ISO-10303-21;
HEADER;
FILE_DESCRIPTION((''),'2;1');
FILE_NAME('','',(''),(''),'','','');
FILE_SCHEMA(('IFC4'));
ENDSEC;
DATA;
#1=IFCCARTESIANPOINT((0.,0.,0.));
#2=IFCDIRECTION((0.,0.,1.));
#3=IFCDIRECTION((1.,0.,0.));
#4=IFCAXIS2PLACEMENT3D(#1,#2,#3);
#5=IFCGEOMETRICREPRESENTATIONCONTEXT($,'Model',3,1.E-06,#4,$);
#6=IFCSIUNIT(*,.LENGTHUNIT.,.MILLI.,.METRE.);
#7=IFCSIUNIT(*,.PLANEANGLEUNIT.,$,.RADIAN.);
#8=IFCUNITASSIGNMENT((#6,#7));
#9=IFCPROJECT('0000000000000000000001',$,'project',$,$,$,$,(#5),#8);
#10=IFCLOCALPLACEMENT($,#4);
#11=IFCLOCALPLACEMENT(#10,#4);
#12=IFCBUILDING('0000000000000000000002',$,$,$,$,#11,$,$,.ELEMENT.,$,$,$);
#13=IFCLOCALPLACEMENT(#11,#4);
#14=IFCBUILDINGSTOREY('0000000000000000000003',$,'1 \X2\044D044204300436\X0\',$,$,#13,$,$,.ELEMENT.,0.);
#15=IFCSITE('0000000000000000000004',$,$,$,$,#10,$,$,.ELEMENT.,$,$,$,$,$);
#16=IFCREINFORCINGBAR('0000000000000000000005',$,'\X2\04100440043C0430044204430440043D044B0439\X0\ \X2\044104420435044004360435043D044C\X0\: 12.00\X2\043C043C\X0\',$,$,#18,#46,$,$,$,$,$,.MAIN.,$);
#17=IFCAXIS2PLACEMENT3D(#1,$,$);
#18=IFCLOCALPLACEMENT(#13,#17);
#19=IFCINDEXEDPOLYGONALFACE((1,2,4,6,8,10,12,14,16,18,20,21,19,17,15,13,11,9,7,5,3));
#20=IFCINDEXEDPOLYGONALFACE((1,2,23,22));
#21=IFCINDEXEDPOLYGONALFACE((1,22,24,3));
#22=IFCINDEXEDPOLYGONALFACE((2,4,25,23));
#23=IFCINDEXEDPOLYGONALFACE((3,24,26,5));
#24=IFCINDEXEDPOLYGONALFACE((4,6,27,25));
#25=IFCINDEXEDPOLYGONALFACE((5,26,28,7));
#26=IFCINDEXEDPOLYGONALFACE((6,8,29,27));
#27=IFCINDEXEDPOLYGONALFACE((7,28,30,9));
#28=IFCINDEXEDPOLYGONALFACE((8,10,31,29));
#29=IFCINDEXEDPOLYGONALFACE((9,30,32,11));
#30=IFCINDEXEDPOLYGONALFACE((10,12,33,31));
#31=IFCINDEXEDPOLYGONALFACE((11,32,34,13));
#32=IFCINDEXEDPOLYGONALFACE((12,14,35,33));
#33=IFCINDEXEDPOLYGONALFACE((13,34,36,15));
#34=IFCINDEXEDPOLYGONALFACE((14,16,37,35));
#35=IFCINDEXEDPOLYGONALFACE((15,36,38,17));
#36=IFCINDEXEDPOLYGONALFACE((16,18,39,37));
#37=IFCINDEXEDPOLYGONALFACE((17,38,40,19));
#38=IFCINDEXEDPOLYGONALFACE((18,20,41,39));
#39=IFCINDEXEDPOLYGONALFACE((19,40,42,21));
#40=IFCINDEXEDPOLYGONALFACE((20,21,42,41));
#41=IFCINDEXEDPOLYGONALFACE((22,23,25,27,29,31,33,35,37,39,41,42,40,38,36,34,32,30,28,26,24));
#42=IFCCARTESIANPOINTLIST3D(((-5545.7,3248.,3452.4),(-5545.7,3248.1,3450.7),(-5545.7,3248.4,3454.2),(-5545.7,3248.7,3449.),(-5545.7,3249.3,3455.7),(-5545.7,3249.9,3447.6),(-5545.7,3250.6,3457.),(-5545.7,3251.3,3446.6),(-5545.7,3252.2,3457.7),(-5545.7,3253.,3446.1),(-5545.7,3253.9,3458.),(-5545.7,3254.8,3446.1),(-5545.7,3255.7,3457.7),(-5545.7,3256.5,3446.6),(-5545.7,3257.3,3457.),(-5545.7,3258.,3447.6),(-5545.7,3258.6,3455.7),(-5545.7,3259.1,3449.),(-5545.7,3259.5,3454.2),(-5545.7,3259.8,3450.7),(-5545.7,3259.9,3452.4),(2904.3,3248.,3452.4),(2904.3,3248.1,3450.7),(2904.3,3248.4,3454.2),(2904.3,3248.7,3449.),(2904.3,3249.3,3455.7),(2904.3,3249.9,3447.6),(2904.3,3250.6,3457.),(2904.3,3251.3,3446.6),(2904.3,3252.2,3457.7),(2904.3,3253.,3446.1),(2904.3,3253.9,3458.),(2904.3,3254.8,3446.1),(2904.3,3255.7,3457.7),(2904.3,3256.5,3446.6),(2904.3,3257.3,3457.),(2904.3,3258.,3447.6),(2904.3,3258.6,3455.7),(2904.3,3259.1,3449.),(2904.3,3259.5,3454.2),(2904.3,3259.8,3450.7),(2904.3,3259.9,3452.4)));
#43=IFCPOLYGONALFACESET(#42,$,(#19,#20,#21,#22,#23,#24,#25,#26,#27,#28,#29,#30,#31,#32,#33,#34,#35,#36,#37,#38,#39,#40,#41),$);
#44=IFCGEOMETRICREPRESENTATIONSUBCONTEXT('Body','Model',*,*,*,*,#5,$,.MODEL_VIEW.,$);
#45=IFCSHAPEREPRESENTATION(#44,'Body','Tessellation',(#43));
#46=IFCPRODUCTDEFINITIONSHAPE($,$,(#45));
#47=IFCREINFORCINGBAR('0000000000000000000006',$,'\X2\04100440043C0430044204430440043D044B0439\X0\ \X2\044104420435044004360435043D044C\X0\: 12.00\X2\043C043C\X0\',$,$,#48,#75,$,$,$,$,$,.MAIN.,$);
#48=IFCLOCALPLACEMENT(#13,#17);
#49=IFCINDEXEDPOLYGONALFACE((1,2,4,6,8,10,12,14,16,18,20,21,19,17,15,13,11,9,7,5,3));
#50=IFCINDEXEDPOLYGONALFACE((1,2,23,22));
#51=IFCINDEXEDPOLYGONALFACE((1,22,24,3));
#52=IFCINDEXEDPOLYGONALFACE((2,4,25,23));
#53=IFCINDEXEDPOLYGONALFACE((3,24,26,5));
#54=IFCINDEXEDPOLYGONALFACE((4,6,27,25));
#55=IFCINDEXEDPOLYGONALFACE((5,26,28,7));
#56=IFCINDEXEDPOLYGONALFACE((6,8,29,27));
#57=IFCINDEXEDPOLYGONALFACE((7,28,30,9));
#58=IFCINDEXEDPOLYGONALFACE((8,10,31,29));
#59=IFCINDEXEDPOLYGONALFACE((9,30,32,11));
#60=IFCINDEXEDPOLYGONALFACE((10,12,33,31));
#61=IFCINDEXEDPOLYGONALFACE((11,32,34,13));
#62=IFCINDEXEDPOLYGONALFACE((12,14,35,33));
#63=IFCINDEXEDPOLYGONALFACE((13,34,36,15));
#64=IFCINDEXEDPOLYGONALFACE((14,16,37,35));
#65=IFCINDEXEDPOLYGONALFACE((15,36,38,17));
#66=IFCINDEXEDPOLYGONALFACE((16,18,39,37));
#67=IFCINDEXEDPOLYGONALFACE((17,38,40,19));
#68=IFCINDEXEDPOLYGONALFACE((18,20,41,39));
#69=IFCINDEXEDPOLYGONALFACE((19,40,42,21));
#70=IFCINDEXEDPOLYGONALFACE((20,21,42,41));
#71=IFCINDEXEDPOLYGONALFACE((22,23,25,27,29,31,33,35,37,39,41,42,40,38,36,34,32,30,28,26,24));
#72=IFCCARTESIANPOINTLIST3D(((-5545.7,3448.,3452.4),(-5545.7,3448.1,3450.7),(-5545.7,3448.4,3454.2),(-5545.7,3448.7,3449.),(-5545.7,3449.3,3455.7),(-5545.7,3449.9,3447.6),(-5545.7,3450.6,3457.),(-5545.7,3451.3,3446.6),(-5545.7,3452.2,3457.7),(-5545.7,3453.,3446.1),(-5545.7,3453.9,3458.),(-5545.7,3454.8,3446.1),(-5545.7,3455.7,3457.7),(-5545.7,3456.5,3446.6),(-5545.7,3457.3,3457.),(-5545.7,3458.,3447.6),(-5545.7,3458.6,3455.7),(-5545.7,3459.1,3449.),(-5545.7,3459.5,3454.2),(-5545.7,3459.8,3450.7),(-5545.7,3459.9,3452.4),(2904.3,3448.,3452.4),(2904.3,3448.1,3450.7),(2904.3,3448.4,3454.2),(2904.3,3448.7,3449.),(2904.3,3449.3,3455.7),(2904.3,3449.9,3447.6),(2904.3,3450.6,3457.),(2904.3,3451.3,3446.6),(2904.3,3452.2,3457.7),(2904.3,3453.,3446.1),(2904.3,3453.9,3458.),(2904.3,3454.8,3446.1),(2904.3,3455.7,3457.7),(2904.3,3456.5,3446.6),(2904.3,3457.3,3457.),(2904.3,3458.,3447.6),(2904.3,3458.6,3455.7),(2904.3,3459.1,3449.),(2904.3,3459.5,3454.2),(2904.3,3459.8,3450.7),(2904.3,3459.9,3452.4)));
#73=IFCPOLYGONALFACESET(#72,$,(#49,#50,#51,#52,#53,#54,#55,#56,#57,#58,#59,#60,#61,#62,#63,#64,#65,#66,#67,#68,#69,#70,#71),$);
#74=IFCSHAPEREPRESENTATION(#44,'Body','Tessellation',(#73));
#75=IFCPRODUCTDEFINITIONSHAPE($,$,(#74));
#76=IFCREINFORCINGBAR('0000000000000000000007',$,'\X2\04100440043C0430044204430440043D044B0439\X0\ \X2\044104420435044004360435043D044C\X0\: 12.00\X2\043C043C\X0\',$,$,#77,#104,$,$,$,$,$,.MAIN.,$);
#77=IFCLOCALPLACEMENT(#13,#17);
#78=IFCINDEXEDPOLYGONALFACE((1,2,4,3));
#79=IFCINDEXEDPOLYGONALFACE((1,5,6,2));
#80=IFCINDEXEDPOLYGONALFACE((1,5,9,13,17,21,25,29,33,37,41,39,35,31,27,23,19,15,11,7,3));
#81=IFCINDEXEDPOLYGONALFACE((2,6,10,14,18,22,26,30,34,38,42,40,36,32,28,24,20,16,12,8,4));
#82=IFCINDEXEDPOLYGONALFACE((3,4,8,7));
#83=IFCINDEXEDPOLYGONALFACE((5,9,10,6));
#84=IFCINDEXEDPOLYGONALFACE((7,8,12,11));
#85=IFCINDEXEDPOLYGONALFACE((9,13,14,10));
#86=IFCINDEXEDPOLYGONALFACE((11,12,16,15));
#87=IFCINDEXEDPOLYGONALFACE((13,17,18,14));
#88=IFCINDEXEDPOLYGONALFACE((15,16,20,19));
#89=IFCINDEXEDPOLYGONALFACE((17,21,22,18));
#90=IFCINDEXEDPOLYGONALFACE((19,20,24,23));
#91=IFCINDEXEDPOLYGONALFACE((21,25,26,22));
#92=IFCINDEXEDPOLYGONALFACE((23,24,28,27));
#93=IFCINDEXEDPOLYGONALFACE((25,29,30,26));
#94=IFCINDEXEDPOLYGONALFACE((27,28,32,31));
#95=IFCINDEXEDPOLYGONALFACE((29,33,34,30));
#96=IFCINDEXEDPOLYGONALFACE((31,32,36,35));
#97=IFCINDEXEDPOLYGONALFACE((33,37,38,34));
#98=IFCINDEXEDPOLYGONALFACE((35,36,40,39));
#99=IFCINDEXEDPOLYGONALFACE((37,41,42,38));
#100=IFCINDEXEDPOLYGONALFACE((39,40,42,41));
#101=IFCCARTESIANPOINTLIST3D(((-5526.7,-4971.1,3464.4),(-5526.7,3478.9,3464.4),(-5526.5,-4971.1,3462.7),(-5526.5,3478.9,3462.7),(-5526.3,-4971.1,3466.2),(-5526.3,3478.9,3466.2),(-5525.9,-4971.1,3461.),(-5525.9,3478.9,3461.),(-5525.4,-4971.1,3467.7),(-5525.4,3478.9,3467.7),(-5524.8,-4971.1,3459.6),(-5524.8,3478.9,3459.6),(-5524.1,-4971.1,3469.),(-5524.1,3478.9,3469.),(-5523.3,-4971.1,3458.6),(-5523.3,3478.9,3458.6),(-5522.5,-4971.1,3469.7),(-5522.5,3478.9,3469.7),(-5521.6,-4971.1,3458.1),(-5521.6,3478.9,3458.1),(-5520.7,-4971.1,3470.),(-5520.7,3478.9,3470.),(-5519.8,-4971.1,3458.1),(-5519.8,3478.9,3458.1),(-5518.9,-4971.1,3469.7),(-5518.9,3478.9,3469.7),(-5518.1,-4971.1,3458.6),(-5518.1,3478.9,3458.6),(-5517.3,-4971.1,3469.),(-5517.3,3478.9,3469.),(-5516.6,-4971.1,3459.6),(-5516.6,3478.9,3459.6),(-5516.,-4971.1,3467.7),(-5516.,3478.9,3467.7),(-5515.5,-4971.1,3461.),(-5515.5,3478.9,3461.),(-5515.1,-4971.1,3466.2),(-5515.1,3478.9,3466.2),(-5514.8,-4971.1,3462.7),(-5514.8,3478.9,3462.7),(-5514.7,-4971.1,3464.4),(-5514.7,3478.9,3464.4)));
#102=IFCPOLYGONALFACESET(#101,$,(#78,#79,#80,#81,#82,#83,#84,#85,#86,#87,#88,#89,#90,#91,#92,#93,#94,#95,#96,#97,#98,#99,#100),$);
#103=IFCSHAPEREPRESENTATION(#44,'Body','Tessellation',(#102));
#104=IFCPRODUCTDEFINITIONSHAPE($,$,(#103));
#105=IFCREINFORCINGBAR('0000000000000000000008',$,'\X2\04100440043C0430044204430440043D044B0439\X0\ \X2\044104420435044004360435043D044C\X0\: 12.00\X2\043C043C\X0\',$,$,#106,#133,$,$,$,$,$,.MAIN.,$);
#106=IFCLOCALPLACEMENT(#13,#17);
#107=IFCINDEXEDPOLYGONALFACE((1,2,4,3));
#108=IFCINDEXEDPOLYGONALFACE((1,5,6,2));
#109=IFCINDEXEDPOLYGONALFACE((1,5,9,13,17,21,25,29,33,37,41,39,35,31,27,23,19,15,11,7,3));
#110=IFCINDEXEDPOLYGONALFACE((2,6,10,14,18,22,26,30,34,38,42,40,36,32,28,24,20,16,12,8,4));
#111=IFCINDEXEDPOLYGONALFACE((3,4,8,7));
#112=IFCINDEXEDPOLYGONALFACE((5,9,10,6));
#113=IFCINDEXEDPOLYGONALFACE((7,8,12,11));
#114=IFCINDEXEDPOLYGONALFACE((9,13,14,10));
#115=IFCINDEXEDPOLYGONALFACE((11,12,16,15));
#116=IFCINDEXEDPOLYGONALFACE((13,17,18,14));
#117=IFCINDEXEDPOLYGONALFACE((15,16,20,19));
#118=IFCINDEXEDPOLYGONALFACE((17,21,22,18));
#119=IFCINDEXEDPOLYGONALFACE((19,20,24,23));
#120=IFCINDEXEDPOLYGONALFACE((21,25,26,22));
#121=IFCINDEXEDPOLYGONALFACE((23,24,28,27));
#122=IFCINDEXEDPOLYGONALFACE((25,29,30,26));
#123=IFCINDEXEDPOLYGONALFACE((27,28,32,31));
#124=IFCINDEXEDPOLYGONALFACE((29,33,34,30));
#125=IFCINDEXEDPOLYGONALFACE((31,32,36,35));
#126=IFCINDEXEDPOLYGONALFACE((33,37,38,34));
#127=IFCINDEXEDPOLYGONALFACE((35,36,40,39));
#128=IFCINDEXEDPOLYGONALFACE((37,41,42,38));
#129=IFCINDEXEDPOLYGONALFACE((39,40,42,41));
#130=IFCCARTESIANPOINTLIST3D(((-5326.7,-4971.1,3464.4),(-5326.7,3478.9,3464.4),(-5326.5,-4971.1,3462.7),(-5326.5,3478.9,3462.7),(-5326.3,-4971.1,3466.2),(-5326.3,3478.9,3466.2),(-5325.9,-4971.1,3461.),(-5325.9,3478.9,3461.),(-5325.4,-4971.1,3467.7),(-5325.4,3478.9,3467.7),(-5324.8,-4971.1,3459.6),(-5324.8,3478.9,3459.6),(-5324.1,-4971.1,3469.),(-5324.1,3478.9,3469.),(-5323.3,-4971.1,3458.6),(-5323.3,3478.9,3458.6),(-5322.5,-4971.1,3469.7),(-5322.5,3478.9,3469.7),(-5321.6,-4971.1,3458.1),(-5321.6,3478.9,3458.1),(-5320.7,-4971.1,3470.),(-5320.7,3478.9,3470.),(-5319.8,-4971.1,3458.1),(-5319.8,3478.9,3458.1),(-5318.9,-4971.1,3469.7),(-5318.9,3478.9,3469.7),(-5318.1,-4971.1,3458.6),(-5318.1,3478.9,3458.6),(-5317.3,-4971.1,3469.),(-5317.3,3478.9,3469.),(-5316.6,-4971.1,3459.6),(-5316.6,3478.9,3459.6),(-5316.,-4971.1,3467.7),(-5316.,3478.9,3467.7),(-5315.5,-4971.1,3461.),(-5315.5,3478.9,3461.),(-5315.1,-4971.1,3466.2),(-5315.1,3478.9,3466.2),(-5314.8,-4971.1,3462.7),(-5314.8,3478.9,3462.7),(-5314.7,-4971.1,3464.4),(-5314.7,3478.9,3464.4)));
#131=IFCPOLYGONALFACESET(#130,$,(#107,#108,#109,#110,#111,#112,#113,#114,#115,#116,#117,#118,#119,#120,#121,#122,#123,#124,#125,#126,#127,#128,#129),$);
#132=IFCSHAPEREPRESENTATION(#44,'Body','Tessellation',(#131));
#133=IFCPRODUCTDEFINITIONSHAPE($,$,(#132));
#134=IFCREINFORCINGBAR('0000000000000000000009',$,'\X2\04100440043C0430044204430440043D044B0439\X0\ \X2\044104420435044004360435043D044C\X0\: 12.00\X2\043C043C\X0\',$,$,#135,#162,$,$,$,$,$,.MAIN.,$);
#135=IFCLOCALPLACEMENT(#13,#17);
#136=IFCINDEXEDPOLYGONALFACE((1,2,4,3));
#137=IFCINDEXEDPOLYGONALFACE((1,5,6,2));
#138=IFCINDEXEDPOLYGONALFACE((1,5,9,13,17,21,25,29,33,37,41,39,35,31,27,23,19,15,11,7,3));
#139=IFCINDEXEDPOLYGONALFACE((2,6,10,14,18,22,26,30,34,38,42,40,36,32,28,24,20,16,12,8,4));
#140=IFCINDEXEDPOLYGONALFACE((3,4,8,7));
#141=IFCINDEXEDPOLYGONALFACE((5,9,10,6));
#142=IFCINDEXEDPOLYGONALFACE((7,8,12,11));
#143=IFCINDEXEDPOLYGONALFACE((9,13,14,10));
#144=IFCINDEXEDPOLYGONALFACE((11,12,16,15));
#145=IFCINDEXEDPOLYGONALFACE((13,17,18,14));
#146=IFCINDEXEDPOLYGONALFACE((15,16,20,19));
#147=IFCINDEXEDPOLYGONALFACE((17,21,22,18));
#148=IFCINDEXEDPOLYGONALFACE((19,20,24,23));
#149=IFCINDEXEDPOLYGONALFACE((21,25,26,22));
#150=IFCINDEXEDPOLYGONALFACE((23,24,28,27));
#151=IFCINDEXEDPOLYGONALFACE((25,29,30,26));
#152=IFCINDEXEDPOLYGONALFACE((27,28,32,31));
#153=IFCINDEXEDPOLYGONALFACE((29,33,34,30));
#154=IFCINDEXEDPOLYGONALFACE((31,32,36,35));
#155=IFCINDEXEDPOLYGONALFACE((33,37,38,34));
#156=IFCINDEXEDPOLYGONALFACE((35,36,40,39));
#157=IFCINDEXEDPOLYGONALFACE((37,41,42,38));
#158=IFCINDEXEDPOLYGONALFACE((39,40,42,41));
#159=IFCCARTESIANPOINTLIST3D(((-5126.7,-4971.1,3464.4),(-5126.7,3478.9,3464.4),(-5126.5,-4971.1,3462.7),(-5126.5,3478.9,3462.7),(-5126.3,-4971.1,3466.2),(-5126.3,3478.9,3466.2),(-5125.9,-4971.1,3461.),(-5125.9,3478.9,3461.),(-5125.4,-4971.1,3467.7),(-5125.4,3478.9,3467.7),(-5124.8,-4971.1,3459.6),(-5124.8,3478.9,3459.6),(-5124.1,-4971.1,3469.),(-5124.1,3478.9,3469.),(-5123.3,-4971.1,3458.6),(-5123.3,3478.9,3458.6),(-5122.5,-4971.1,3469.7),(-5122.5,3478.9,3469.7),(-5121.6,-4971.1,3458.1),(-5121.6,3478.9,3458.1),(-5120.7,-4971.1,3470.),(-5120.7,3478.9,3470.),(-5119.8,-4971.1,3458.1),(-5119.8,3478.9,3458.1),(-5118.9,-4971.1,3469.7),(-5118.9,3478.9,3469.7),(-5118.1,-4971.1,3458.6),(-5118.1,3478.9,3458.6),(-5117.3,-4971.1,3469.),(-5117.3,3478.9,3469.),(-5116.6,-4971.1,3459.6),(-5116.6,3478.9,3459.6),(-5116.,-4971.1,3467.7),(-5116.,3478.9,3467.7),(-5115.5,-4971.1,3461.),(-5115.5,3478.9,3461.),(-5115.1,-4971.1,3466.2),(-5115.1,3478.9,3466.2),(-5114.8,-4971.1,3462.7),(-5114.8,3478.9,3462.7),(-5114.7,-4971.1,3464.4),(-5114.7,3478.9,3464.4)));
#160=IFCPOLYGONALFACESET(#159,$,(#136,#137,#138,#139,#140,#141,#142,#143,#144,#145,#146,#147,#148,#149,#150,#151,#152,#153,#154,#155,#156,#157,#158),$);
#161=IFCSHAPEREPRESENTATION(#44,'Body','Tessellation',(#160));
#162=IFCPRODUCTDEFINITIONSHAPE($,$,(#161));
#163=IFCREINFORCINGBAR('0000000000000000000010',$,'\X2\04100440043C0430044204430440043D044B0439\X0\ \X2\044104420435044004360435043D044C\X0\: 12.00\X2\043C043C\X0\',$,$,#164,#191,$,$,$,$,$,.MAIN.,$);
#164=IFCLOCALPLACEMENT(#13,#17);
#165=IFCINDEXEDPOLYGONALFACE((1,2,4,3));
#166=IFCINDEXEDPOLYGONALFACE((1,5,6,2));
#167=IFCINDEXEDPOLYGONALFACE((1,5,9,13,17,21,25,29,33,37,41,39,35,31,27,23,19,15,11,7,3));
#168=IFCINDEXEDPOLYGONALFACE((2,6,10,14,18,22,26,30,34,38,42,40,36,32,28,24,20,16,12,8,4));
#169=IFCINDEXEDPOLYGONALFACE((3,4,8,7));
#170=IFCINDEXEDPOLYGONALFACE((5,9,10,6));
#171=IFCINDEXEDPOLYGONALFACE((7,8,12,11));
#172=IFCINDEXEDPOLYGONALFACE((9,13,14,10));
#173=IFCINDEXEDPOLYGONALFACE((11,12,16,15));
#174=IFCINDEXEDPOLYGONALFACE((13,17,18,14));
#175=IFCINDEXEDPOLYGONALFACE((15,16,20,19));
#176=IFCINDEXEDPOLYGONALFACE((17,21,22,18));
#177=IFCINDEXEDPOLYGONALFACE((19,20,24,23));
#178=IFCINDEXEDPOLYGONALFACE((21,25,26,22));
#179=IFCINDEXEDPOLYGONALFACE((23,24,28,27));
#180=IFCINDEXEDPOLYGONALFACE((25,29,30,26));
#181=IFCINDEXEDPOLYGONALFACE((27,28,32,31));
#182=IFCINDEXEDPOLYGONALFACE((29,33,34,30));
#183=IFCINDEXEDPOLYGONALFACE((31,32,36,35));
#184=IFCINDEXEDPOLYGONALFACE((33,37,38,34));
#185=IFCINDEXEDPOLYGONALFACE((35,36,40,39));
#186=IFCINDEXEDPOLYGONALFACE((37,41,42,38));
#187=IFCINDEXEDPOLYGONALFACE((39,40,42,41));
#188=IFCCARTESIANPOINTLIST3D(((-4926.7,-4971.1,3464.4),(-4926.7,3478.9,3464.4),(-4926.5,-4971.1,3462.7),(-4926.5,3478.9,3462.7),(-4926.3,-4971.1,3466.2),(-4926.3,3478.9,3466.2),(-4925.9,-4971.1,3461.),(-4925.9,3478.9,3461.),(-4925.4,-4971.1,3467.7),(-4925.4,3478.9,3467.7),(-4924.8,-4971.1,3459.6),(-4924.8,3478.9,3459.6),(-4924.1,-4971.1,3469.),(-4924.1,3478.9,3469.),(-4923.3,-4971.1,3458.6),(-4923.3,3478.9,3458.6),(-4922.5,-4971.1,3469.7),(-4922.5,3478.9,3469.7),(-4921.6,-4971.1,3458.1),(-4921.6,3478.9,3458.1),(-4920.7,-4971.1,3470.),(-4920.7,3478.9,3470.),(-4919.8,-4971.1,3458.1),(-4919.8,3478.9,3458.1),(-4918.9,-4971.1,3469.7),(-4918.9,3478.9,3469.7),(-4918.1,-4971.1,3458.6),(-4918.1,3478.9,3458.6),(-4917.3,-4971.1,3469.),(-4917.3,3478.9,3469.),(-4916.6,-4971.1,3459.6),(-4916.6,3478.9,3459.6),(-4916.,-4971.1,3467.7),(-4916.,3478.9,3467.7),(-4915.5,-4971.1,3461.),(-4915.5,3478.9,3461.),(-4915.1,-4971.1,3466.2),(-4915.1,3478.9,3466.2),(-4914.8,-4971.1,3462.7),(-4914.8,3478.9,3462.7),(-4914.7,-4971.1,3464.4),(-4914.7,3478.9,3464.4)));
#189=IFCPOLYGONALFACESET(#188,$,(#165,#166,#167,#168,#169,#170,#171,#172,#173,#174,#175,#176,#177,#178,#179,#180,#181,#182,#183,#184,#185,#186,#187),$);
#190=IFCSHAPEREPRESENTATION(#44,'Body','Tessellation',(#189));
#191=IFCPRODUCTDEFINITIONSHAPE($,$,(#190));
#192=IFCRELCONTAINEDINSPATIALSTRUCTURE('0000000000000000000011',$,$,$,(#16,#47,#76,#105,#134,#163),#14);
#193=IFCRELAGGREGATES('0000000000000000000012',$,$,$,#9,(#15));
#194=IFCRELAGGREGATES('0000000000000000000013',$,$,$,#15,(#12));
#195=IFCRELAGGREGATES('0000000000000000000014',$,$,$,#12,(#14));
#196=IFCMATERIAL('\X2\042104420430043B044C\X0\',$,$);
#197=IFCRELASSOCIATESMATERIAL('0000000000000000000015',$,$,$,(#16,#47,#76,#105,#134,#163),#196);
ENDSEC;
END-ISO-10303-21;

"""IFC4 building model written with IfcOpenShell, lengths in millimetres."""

from ifc_helpers import new_model, entity, si_unit, origin_with_axes, place, context, subcontext, project, spatial, source, transform, mapped, material, element, save


model = new_model("IFC4")

# Units and contexts
model_context = context("Model", 3, precision=1e-06, world=origin_with_axes())
body_context = subcontext(model_context, "Body", "Model", "MODEL_VIEW")
ifc_project = project(units=[si_unit("LENGTHUNIT", "METRE", prefix="MILLI"), si_unit("PLANEANGLEUNIT", "RADIAN")], contexts=[model_context])

# Site, building, storey
site_placement = place(None, origin_with_axes())
site = spatial("IfcSite", under=ifc_project, at=site_placement, CompositionType="ELEMENT")
building_placement = place(site_placement, origin_with_axes())
building = spatial("IfcBuilding", under=site, at=building_placement, CompositionType="ELEMENT")
storey_placement = place(building_placement, origin_with_axes())
storey = spatial("IfcBuildingStorey", under=building, at=storey_placement, Name="1 этаж", CompositionType="ELEMENT", Elevation=0.0)

# Reinforcing bars
ifc_material = material(Name="Сталь")
shared_shape = source(origin_with_axes(), body_context, "Body", "AdvancedSweptSolid", [
    entity("IfcSweptDiskSolid", entity("IfcIndexedPolyCurve", entity("IfcCartesianPointList3D", [[0.0, 0.0, 0.0], [8450.0, 0.0, 0.0]]), [entity("IfcLineIndex", [1, 2])]), 6.0),
])
reinforcing_bar_1_placement = place(storey_placement, origin_with_axes())
element("IfcReinforcingBar", 1, at=reinforcing_bar_1_placement, inside=storey, material=ifc_material, Name="Арматурный стержень: 12.00мм", PredefinedType="MAIN", context=body_context, shape_type="MappedRepresentation", body=[
    mapped(shared_shape, transform((-5545.7, 3253.9, 3452.0), x_axis=(1.0, 0.0, 0.0), y_axis=(0.0, 1.0, 0.0), z_axis=(0.0, 0.0, 1.0), scale=1.0)),
])
reinforcing_bar_2_placement = place(storey_placement, origin_with_axes())
element("IfcReinforcingBar", 2, at=reinforcing_bar_2_placement, inside=storey, material=ifc_material, Name="Арматурный стержень: 12.00мм", PredefinedType="MAIN", context=body_context, shape_type="MappedRepresentation", body=[
    mapped(shared_shape, transform((-5545.7, 3453.9, 3452.0), x_axis=(1.0, 0.0, 0.0), y_axis=(0.0, 1.0, 0.0), z_axis=(0.0, 0.0, 1.0), scale=1.0)),
])
reinforcing_bar_3_placement = place(storey_placement, origin_with_axes())
element("IfcReinforcingBar", 3, at=reinforcing_bar_3_placement, inside=storey, material=ifc_material, Name="Арматурный стержень: 12.00мм", PredefinedType="MAIN", context=body_context, shape_type="MappedRepresentation", body=[
    mapped(shared_shape, transform((-5520.7, -4971.1, 3464.0), x_axis=(0.0, 1.0, 0.0), y_axis=(-1.0, 0.0, 0.0), z_axis=(0.0, 0.0, 1.0), scale=1.0)),
])
reinforcing_bar_4_placement = place(storey_placement, origin_with_axes())
element("IfcReinforcingBar", 4, at=reinforcing_bar_4_placement, inside=storey, material=ifc_material, Name="Арматурный стержень: 12.00мм", PredefinedType="MAIN", context=body_context, shape_type="MappedRepresentation", body=[
    mapped(shared_shape, transform((-5320.7, -4971.1, 3464.0), x_axis=(0.0, 1.0, 0.0), y_axis=(-1.0, 0.0, 0.0), z_axis=(0.0, 0.0, 1.0), scale=1.0)),
])
reinforcing_bar_5_placement = place(storey_placement, origin_with_axes())
element("IfcReinforcingBar", 5, at=reinforcing_bar_5_placement, inside=storey, material=ifc_material, Name="Арматурный стержень: 12.00мм", PredefinedType="MAIN", context=body_context, shape_type="MappedRepresentation", body=[
    mapped(shared_shape, transform((-5120.7, -4971.1, 3464.0), x_axis=(0.0, 1.0, 0.0), y_axis=(-1.0, 0.0, 0.0), z_axis=(0.0, 0.0, 1.0), scale=1.0)),
])
reinforcing_bar_6_placement = place(storey_placement, origin_with_axes())
element("IfcReinforcingBar", 6, at=reinforcing_bar_6_placement, inside=storey, material=ifc_material, Name="Арматурный стержень: 12.00мм", PredefinedType="MAIN", context=body_context, shape_type="MappedRepresentation", body=[
    mapped(shared_shape, transform((-4920.7, -4971.1, 3464.0), x_axis=(0.0, 1.0, 0.0), y_axis=(-1.0, 0.0, 0.0), z_axis=(0.0, 0.0, 1.0), scale=1.0)),
])

save(model, "model.ifc")
